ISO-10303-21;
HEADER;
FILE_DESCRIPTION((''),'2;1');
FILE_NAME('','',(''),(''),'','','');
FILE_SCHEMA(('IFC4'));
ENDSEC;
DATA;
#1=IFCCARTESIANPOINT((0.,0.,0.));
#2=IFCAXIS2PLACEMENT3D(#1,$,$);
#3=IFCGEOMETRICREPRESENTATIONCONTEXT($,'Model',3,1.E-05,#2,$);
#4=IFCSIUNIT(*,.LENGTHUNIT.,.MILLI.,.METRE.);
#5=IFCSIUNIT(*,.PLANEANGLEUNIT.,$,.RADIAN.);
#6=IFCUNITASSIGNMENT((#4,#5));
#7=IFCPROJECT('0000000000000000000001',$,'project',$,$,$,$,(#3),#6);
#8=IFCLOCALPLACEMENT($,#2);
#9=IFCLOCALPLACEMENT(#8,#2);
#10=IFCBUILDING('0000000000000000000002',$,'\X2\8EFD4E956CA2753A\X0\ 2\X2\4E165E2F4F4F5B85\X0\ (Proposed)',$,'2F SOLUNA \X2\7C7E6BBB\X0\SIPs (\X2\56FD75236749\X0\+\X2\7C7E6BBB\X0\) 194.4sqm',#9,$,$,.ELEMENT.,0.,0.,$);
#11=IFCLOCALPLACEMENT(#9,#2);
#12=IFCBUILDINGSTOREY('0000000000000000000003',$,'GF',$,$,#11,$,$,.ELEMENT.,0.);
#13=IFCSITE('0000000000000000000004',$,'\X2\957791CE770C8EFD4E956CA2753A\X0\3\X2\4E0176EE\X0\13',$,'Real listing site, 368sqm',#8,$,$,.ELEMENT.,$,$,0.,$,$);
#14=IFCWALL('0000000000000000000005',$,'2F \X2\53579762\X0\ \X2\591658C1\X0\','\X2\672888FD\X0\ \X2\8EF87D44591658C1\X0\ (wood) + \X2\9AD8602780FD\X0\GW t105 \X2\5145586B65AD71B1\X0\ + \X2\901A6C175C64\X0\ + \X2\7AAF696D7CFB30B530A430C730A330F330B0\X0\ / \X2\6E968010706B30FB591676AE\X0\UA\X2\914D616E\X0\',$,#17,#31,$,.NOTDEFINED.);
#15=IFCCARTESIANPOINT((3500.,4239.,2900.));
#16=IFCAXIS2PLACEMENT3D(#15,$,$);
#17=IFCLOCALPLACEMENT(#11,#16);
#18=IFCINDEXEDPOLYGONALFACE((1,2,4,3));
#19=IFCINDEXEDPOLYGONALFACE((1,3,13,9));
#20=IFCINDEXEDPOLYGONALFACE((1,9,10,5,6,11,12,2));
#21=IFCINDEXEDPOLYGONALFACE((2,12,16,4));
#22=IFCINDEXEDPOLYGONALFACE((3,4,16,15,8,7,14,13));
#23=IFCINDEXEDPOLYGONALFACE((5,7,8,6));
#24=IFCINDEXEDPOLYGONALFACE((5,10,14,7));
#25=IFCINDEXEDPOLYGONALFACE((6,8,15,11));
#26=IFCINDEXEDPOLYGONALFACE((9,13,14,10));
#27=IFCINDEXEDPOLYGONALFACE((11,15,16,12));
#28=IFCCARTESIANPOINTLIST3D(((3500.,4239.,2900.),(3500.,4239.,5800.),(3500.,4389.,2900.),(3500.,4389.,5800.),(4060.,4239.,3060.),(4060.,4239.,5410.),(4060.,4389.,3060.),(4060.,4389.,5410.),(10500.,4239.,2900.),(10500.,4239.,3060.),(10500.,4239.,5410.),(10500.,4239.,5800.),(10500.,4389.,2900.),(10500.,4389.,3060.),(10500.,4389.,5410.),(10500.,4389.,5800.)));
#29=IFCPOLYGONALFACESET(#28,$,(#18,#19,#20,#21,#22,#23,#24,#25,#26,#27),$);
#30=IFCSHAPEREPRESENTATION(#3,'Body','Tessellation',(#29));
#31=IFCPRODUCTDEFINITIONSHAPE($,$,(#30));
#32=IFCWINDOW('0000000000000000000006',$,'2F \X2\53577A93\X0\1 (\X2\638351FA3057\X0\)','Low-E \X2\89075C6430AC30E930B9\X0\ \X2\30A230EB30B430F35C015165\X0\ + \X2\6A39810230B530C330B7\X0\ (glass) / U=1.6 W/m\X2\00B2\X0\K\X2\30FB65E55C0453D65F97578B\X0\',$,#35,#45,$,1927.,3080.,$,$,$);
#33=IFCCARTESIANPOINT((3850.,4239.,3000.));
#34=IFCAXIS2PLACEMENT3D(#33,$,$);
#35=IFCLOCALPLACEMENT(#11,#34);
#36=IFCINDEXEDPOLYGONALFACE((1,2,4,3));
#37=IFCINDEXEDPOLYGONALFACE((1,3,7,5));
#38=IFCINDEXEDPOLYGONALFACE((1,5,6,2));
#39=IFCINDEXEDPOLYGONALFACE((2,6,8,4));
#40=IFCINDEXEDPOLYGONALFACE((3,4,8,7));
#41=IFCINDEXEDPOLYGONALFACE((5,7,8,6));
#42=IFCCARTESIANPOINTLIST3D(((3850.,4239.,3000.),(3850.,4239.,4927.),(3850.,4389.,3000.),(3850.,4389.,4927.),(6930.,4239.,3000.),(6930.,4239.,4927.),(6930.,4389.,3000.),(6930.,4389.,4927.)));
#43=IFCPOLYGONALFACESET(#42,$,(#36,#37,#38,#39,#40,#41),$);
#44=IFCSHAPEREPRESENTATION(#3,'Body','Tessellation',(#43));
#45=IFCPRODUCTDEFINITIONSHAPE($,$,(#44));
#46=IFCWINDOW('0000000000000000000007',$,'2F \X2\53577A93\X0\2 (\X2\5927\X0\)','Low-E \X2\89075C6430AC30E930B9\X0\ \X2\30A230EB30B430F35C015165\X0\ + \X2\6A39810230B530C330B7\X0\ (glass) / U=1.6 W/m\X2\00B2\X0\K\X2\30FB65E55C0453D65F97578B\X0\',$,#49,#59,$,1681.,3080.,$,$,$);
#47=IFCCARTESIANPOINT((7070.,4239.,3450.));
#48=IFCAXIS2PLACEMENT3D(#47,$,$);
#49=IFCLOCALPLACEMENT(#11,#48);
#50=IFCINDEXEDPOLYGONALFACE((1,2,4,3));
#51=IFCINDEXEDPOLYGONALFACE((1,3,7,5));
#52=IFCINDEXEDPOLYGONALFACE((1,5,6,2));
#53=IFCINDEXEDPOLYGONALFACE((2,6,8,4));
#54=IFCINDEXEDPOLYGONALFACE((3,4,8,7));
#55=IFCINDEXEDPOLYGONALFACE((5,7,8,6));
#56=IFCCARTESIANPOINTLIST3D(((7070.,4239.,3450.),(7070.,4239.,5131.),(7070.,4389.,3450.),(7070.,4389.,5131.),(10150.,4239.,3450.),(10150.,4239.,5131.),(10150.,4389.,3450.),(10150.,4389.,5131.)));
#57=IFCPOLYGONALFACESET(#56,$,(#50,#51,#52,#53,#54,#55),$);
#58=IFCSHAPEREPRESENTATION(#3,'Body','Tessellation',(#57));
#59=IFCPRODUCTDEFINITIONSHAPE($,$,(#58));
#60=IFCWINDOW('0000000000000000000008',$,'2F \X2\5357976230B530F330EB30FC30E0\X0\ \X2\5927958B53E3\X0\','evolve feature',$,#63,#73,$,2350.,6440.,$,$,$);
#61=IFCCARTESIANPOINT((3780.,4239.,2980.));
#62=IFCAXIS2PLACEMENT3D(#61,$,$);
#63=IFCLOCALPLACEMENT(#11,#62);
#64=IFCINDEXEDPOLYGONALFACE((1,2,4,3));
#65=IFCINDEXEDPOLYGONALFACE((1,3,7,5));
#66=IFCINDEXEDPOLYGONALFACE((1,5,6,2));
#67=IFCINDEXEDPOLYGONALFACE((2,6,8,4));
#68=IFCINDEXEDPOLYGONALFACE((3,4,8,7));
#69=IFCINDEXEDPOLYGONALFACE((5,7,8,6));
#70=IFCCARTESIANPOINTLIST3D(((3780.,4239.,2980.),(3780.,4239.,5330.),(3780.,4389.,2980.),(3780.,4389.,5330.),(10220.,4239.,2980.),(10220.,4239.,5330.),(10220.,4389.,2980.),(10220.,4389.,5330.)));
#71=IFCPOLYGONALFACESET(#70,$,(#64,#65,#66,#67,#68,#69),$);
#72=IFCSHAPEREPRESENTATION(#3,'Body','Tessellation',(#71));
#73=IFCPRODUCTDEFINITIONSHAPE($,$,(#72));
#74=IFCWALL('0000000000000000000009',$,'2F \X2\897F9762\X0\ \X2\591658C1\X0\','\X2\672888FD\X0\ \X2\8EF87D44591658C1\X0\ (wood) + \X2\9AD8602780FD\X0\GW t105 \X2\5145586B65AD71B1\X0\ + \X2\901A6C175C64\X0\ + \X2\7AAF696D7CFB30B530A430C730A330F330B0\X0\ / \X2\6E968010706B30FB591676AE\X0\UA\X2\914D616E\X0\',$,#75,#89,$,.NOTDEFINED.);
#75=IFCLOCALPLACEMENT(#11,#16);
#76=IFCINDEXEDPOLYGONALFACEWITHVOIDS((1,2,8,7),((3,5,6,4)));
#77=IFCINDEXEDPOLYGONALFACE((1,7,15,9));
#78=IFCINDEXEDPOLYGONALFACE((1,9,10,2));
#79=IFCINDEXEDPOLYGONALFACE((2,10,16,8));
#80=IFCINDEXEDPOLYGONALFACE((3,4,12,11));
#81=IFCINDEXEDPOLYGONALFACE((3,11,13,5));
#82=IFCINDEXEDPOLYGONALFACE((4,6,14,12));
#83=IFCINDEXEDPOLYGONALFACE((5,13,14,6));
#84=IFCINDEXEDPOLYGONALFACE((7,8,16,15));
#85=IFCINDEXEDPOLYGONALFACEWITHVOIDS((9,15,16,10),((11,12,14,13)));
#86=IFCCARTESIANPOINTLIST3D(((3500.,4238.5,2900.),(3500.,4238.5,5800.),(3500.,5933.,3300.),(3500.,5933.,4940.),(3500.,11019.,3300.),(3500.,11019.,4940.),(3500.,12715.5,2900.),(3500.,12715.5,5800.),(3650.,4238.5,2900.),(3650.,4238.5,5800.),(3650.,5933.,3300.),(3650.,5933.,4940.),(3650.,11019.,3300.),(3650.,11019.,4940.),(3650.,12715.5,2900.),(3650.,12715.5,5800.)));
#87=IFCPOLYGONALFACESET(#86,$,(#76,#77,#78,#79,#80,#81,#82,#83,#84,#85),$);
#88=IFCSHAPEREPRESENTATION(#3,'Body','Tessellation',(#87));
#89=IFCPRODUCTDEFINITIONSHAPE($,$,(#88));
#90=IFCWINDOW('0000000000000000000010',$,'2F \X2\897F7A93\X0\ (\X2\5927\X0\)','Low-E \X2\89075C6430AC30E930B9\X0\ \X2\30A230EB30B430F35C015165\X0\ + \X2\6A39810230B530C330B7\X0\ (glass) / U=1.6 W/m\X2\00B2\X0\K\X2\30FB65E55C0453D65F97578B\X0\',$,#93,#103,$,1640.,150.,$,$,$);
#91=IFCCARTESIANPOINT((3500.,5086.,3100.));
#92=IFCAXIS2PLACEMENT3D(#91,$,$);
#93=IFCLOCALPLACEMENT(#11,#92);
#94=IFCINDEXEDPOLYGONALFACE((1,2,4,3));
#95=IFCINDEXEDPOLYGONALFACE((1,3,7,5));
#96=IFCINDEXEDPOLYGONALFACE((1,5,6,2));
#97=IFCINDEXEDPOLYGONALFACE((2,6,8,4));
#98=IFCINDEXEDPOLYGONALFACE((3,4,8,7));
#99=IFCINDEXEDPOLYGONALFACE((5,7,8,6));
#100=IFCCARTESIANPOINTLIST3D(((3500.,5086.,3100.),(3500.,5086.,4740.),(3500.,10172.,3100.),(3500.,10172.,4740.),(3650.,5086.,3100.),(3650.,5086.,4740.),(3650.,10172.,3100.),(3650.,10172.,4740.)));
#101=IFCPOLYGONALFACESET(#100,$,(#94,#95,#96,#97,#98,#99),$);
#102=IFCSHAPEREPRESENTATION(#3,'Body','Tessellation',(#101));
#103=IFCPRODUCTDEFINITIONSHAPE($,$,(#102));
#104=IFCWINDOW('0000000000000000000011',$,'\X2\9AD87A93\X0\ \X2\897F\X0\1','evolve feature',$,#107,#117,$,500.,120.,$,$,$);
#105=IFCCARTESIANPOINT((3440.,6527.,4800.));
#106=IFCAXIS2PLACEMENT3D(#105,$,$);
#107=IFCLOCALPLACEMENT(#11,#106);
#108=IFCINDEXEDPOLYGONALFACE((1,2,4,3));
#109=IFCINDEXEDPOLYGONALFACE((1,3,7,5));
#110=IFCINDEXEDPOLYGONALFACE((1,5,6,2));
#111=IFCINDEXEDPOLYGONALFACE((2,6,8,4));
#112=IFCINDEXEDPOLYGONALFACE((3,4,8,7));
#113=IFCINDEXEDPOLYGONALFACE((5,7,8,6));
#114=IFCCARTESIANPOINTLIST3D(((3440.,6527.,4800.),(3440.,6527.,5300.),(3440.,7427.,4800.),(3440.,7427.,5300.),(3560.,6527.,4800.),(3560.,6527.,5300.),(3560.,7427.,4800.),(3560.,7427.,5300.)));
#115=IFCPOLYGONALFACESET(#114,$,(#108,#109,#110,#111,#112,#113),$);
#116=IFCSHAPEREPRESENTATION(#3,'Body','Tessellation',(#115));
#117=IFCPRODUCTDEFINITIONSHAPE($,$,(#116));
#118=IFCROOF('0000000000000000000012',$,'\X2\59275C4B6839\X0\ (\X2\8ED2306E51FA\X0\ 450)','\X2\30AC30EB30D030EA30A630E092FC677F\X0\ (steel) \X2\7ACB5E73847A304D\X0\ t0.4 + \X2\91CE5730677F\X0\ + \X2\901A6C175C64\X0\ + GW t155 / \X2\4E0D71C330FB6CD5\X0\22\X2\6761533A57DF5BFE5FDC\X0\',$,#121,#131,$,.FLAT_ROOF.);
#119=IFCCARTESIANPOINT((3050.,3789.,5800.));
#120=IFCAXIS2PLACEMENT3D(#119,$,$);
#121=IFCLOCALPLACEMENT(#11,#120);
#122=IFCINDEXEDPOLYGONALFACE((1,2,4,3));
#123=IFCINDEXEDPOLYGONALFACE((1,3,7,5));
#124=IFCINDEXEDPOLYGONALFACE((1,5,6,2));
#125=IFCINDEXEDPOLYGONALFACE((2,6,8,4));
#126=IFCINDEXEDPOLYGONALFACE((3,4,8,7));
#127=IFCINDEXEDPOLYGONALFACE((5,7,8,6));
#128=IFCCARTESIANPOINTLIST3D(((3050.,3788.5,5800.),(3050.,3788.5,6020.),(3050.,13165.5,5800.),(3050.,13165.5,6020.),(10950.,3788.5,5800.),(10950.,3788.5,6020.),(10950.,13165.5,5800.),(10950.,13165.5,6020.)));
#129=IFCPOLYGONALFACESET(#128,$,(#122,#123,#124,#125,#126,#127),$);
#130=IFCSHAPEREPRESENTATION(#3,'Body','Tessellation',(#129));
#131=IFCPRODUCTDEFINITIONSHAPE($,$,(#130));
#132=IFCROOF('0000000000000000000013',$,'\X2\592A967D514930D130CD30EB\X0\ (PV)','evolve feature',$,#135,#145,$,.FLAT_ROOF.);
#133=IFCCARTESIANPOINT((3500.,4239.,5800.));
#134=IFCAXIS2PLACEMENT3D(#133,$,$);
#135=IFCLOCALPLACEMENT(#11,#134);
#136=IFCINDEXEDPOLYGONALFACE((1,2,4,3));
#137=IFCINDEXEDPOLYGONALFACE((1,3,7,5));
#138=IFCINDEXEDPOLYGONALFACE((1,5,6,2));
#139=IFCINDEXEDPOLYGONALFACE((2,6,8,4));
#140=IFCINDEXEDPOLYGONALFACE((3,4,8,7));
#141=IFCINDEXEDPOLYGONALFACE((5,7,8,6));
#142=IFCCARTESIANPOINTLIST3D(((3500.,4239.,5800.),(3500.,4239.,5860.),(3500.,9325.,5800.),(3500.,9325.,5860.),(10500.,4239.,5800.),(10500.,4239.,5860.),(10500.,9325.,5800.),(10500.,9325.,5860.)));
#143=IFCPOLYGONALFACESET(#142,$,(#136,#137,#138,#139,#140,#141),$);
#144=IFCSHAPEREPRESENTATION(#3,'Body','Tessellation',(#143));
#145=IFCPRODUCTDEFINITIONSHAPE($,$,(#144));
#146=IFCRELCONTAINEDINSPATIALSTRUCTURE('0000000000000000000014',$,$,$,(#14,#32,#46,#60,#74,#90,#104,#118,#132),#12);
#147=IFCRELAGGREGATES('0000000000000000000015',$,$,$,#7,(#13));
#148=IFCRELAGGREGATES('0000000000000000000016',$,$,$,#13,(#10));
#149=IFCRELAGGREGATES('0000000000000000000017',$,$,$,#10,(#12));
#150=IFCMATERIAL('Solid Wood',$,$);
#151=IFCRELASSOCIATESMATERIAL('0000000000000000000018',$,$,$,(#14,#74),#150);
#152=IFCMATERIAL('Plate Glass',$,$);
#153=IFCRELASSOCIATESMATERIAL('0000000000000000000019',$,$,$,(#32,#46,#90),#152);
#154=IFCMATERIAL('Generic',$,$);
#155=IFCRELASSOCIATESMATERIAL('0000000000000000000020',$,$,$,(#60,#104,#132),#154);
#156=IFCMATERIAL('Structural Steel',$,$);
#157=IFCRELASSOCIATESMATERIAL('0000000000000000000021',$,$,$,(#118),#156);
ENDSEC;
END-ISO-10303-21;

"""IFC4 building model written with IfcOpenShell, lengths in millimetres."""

from ifc_helpers import new_model, si_unit, frame, frame_2d, origin, place, context, project, spatial, rectangle, extrude, material, element, fill, save


model = new_model("IFC4")

# Units and contexts
model_context = context("Model", 3, precision=1e-05, world=origin())
ifc_project = project(units=[si_unit("LENGTHUNIT", "METRE", prefix="MILLI"), si_unit("PLANEANGLEUNIT", "RADIAN")], contexts=[model_context])

# Site, building, storey
site_placement = place(None, origin())
site = spatial("IfcSite", under=ifc_project, at=site_placement, Name="長野県軽井沢町3丁目13", ObjectType="Real listing site, 368sqm", CompositionType="ELEMENT", RefElevation=0.0)
building_placement = place(site_placement, origin())
building = spatial("IfcBuilding", under=site, at=building_placement, Name="軽井沢町 2世帯住宅 (Proposed)", ObjectType="2F SOLUNA 籾殻SIPs (国産杉+籾殻) 194.4sqm", CompositionType="ELEMENT", ElevationOfRefHeight=0.0, ElevationOfTerrain=0.0)
storey_placement = place(building_placement, origin())
storey = spatial("IfcBuildingStorey", under=building, at=storey_placement, Name="GF", CompositionType="ELEMENT", Elevation=0.0)

# Shared definitions
ifc_material_1 = material(Name="Solid Wood")
ifc_material_2 = material(Name="Generic")

# Shared definitions
ifc_material_3 = material(Name="Plate Glass")

# Walls, openings, windows
wall_1_placement = place(storey_placement, frame((3500.0, 4239.0, 2900.0)))
wall_1 = element("IfcWall", 1, at=wall_1_placement, inside=storey, material=ifc_material_1, Name="2F 南面 外壁", Description="木製 軸組外壁 (wood) + 高性能GW t105 充填断熱 + 通気層 + 窯業系サイディング / 準耐火・外皮UA配慮", PredefinedType="NOTDEFINED", context=model_context, shape_type="SweptSolid", body=[
    extrude(rectangle(XDim=7000.0, YDim=150.0, at=frame_2d((3500.0, 75.0))), frame((3500.0, 4239.0, 2900.0)), (0.0, 0.0, 1.0), 2900.0),
])
opening_1_placement = place(storey_placement, frame((3850.0, 4239.0, 3000.0)))
opening_1 = element("IfcOpeningElement", 2, at=opening_1_placement, cuts=wall_1, PredefinedType="NOTDEFINED", context=model_context, shape_type="SweptSolid", body=[
    extrude(rectangle(XDim=3080.0, YDim=150.0, at=frame_2d((1540.0, 75.0))), frame((3850.0, 4239.0, 3000.0)), (0.0, 0.0, 1.0), 1927.0),
])
opening_2_placement = place(storey_placement, frame((7070.0, 4239.0, 3450.0)))
opening_2 = element("IfcOpeningElement", 3, at=opening_2_placement, cuts=wall_1, PredefinedType="NOTDEFINED", context=model_context, shape_type="SweptSolid", body=[
    extrude(rectangle(XDim=3080.0, YDim=150.0, at=frame_2d((1540.0, 75.0))), frame((7070.0, 4239.0, 3450.0)), (0.0, 0.0, 1.0), 1681.0),
])
opening_3_placement = place(storey_placement, frame((3780.0, 4239.0, 2980.0)))
opening_3 = element("IfcOpeningElement", 4, at=opening_3_placement, cuts=wall_1, PredefinedType="NOTDEFINED", context=model_context, shape_type="SweptSolid", body=[
    extrude(rectangle(XDim=6440.0, YDim=150.0, at=frame_2d((3220.0, 75.0))), frame((3780.0, 4239.0, 2980.0)), (0.0, 0.0, 1.0), 2350.0),
])
window_1_placement = place(storey_placement, frame((3850.0, 4239.0, 3000.0)))
window_1 = element("IfcWindow", 5, at=window_1_placement, inside=storey, material=ifc_material_3, Name="2F 南窓1 (掃出し)", Description="Low-E 複層ガラス アルゴン封入 + 樹脂サッシ (glass) / U=1.6 W/m²K・日射取得型", OverallHeight=1927.0, OverallWidth=3080.0, context=model_context, shape_type="SweptSolid", body=[
    extrude(rectangle(XDim=3080.0, YDim=150.0, at=frame_2d((1540.0, 75.0))), frame((3850.0, 4239.0, 3000.0)), (0.0, 0.0, 1.0), 1927.0),
])
fill(opening_1, window_1)
window_2_placement = place(storey_placement, frame((7070.0, 4239.0, 3450.0)))
window_2 = element("IfcWindow", 6, at=window_2_placement, inside=storey, material=ifc_material_3, Name="2F 南窓2 (大)", Description="Low-E 複層ガラス アルゴン封入 + 樹脂サッシ (glass) / U=1.6 W/m²K・日射取得型", OverallHeight=1681.0, OverallWidth=3080.0, context=model_context, shape_type="SweptSolid", body=[
    extrude(rectangle(XDim=3080.0, YDim=150.0, at=frame_2d((1540.0, 75.0))), frame((7070.0, 4239.0, 3450.0)), (0.0, 0.0, 1.0), 1681.0),
])
fill(opening_2, window_2)
window_3_placement = place(storey_placement, frame((3780.0, 4239.0, 2980.0)))
window_3 = element("IfcWindow", 7, at=window_3_placement, inside=storey, material=ifc_material_2, Name="2F 南面サンルーム 大開口", Description="evolve feature", OverallHeight=2350.0, OverallWidth=6440.0, context=model_context, shape_type="SweptSolid", body=[
    extrude(rectangle(XDim=6440.0, YDim=150.0, at=frame_2d((3220.0, 75.0))), frame((3780.0, 4239.0, 2980.0)), (0.0, 0.0, 1.0), 2350.0),
])
fill(opening_3, window_3)
wall_2_placement = place(storey_placement, frame((3500.0, 4239.0, 2900.0)))
wall_2 = element("IfcWall", 8, at=wall_2_placement, inside=storey, material=ifc_material_1, Name="2F 西面 外壁", Description="木製 軸組外壁 (wood) + 高性能GW t105 充填断熱 + 通気層 + 窯業系サイディング / 準耐火・外皮UA配慮", PredefinedType="NOTDEFINED", context=model_context, shape_type="SweptSolid", body=[
    extrude(rectangle(XDim=150.0, YDim=8477.0, at=frame_2d((75.0, 4238.0))), frame((3500.0, 4239.0, 2900.0)), (0.0, 0.0, 1.0), 2900.0),
])
opening_4_placement = place(storey_placement, frame((3500.0, 5086.0, 3100.0)))
opening_4 = element("IfcOpeningElement", 9, at=opening_4_placement, cuts=wall_2, PredefinedType="NOTDEFINED", context=model_context, shape_type="SweptSolid", body=[
    extrude(rectangle(XDim=150.0, YDim=5086.0, at=frame_2d((75.0, 2543.0))), frame((3500.0, 5086.0, 3100.0)), (0.0, 0.0, 1.0), 1640.0),
])
opening_5_placement = place(storey_placement, frame((3440.0, 6527.0, 4800.0)))
opening_5 = element("IfcOpeningElement", 10, at=opening_5_placement, cuts=wall_2, PredefinedType="NOTDEFINED", context=model_context, shape_type="SweptSolid", body=[
    extrude(rectangle(XDim=120.0, YDim=900.0, at=frame_2d((60.0, 450.0))), frame((3440.0, 6527.0, 4800.0)), (0.0, 0.0, 1.0), 500.0),
])
window_4_placement = place(storey_placement, frame((3500.0, 5086.0, 3100.0)))
window_4 = element("IfcWindow", 11, at=window_4_placement, inside=storey, material=ifc_material_3, Name="2F 西窓 (大)", Description="Low-E 複層ガラス アルゴン封入 + 樹脂サッシ (glass) / U=1.6 W/m²K・日射取得型", OverallHeight=1640.0, OverallWidth=150.0, context=model_context, shape_type="SweptSolid", body=[
    extrude(rectangle(XDim=150.0, YDim=5086.0, at=frame_2d((75.0, 2543.0))), frame((3500.0, 5086.0, 3100.0)), (0.0, 0.0, 1.0), 1640.0),
])
fill(opening_4, window_4)
window_5_placement = place(storey_placement, frame((3440.0, 6527.0, 4800.0)))
window_5 = element("IfcWindow", 12, at=window_5_placement, inside=storey, material=ifc_material_2, Name="高窓 西1", Description="evolve feature", OverallHeight=500.0, OverallWidth=120.0, context=model_context, shape_type="SweptSolid", body=[
    extrude(rectangle(XDim=120.0, YDim=900.0, at=frame_2d((60.0, 450.0))), frame((3440.0, 6527.0, 4800.0)), (0.0, 0.0, 1.0), 500.0),
])
fill(opening_5, window_5)

# Roofs
ifc_material_4 = material(Name="Structural Steel")
roof_1_placement = place(storey_placement, frame((3050.0, 3789.0, 5800.0)))
element("IfcRoof", 13, at=roof_1_placement, inside=storey, material=ifc_material_4, Name="大屋根 (軒の出 450)", Description="ガルバリウム鋼板 (steel) 立平葺き t0.4 + 野地板 + 通気層 + GW t155 / 不燃・法22条区域対応", PredefinedType="FLAT_ROOF", context=model_context, shape_type="SweptSolid", body=[
    extrude(rectangle(XDim=7900.0, YDim=9377.0, at=frame_2d((3950.0, 4688.0))), frame((3050.0, 3789.0, 5800.0)), (0.0, 0.0, 1.0), 220.0),
])
roof_2_placement = place(storey_placement, frame((3500.0, 4239.0, 5800.0)))
element("IfcRoof", 14, at=roof_2_placement, inside=storey, material=ifc_material_2, Name="太陽光パネル (PV)", Description="evolve feature", PredefinedType="FLAT_ROOF", context=model_context, shape_type="SweptSolid", body=[
    extrude(rectangle(XDim=7000.0, YDim=5086.0, at=frame_2d((3500.0, 2543.0))), frame((3500.0, 4239.0, 5800.0)), (0.0, 0.0, 1.0), 60.0),
])

save(model, "model.ifc")
